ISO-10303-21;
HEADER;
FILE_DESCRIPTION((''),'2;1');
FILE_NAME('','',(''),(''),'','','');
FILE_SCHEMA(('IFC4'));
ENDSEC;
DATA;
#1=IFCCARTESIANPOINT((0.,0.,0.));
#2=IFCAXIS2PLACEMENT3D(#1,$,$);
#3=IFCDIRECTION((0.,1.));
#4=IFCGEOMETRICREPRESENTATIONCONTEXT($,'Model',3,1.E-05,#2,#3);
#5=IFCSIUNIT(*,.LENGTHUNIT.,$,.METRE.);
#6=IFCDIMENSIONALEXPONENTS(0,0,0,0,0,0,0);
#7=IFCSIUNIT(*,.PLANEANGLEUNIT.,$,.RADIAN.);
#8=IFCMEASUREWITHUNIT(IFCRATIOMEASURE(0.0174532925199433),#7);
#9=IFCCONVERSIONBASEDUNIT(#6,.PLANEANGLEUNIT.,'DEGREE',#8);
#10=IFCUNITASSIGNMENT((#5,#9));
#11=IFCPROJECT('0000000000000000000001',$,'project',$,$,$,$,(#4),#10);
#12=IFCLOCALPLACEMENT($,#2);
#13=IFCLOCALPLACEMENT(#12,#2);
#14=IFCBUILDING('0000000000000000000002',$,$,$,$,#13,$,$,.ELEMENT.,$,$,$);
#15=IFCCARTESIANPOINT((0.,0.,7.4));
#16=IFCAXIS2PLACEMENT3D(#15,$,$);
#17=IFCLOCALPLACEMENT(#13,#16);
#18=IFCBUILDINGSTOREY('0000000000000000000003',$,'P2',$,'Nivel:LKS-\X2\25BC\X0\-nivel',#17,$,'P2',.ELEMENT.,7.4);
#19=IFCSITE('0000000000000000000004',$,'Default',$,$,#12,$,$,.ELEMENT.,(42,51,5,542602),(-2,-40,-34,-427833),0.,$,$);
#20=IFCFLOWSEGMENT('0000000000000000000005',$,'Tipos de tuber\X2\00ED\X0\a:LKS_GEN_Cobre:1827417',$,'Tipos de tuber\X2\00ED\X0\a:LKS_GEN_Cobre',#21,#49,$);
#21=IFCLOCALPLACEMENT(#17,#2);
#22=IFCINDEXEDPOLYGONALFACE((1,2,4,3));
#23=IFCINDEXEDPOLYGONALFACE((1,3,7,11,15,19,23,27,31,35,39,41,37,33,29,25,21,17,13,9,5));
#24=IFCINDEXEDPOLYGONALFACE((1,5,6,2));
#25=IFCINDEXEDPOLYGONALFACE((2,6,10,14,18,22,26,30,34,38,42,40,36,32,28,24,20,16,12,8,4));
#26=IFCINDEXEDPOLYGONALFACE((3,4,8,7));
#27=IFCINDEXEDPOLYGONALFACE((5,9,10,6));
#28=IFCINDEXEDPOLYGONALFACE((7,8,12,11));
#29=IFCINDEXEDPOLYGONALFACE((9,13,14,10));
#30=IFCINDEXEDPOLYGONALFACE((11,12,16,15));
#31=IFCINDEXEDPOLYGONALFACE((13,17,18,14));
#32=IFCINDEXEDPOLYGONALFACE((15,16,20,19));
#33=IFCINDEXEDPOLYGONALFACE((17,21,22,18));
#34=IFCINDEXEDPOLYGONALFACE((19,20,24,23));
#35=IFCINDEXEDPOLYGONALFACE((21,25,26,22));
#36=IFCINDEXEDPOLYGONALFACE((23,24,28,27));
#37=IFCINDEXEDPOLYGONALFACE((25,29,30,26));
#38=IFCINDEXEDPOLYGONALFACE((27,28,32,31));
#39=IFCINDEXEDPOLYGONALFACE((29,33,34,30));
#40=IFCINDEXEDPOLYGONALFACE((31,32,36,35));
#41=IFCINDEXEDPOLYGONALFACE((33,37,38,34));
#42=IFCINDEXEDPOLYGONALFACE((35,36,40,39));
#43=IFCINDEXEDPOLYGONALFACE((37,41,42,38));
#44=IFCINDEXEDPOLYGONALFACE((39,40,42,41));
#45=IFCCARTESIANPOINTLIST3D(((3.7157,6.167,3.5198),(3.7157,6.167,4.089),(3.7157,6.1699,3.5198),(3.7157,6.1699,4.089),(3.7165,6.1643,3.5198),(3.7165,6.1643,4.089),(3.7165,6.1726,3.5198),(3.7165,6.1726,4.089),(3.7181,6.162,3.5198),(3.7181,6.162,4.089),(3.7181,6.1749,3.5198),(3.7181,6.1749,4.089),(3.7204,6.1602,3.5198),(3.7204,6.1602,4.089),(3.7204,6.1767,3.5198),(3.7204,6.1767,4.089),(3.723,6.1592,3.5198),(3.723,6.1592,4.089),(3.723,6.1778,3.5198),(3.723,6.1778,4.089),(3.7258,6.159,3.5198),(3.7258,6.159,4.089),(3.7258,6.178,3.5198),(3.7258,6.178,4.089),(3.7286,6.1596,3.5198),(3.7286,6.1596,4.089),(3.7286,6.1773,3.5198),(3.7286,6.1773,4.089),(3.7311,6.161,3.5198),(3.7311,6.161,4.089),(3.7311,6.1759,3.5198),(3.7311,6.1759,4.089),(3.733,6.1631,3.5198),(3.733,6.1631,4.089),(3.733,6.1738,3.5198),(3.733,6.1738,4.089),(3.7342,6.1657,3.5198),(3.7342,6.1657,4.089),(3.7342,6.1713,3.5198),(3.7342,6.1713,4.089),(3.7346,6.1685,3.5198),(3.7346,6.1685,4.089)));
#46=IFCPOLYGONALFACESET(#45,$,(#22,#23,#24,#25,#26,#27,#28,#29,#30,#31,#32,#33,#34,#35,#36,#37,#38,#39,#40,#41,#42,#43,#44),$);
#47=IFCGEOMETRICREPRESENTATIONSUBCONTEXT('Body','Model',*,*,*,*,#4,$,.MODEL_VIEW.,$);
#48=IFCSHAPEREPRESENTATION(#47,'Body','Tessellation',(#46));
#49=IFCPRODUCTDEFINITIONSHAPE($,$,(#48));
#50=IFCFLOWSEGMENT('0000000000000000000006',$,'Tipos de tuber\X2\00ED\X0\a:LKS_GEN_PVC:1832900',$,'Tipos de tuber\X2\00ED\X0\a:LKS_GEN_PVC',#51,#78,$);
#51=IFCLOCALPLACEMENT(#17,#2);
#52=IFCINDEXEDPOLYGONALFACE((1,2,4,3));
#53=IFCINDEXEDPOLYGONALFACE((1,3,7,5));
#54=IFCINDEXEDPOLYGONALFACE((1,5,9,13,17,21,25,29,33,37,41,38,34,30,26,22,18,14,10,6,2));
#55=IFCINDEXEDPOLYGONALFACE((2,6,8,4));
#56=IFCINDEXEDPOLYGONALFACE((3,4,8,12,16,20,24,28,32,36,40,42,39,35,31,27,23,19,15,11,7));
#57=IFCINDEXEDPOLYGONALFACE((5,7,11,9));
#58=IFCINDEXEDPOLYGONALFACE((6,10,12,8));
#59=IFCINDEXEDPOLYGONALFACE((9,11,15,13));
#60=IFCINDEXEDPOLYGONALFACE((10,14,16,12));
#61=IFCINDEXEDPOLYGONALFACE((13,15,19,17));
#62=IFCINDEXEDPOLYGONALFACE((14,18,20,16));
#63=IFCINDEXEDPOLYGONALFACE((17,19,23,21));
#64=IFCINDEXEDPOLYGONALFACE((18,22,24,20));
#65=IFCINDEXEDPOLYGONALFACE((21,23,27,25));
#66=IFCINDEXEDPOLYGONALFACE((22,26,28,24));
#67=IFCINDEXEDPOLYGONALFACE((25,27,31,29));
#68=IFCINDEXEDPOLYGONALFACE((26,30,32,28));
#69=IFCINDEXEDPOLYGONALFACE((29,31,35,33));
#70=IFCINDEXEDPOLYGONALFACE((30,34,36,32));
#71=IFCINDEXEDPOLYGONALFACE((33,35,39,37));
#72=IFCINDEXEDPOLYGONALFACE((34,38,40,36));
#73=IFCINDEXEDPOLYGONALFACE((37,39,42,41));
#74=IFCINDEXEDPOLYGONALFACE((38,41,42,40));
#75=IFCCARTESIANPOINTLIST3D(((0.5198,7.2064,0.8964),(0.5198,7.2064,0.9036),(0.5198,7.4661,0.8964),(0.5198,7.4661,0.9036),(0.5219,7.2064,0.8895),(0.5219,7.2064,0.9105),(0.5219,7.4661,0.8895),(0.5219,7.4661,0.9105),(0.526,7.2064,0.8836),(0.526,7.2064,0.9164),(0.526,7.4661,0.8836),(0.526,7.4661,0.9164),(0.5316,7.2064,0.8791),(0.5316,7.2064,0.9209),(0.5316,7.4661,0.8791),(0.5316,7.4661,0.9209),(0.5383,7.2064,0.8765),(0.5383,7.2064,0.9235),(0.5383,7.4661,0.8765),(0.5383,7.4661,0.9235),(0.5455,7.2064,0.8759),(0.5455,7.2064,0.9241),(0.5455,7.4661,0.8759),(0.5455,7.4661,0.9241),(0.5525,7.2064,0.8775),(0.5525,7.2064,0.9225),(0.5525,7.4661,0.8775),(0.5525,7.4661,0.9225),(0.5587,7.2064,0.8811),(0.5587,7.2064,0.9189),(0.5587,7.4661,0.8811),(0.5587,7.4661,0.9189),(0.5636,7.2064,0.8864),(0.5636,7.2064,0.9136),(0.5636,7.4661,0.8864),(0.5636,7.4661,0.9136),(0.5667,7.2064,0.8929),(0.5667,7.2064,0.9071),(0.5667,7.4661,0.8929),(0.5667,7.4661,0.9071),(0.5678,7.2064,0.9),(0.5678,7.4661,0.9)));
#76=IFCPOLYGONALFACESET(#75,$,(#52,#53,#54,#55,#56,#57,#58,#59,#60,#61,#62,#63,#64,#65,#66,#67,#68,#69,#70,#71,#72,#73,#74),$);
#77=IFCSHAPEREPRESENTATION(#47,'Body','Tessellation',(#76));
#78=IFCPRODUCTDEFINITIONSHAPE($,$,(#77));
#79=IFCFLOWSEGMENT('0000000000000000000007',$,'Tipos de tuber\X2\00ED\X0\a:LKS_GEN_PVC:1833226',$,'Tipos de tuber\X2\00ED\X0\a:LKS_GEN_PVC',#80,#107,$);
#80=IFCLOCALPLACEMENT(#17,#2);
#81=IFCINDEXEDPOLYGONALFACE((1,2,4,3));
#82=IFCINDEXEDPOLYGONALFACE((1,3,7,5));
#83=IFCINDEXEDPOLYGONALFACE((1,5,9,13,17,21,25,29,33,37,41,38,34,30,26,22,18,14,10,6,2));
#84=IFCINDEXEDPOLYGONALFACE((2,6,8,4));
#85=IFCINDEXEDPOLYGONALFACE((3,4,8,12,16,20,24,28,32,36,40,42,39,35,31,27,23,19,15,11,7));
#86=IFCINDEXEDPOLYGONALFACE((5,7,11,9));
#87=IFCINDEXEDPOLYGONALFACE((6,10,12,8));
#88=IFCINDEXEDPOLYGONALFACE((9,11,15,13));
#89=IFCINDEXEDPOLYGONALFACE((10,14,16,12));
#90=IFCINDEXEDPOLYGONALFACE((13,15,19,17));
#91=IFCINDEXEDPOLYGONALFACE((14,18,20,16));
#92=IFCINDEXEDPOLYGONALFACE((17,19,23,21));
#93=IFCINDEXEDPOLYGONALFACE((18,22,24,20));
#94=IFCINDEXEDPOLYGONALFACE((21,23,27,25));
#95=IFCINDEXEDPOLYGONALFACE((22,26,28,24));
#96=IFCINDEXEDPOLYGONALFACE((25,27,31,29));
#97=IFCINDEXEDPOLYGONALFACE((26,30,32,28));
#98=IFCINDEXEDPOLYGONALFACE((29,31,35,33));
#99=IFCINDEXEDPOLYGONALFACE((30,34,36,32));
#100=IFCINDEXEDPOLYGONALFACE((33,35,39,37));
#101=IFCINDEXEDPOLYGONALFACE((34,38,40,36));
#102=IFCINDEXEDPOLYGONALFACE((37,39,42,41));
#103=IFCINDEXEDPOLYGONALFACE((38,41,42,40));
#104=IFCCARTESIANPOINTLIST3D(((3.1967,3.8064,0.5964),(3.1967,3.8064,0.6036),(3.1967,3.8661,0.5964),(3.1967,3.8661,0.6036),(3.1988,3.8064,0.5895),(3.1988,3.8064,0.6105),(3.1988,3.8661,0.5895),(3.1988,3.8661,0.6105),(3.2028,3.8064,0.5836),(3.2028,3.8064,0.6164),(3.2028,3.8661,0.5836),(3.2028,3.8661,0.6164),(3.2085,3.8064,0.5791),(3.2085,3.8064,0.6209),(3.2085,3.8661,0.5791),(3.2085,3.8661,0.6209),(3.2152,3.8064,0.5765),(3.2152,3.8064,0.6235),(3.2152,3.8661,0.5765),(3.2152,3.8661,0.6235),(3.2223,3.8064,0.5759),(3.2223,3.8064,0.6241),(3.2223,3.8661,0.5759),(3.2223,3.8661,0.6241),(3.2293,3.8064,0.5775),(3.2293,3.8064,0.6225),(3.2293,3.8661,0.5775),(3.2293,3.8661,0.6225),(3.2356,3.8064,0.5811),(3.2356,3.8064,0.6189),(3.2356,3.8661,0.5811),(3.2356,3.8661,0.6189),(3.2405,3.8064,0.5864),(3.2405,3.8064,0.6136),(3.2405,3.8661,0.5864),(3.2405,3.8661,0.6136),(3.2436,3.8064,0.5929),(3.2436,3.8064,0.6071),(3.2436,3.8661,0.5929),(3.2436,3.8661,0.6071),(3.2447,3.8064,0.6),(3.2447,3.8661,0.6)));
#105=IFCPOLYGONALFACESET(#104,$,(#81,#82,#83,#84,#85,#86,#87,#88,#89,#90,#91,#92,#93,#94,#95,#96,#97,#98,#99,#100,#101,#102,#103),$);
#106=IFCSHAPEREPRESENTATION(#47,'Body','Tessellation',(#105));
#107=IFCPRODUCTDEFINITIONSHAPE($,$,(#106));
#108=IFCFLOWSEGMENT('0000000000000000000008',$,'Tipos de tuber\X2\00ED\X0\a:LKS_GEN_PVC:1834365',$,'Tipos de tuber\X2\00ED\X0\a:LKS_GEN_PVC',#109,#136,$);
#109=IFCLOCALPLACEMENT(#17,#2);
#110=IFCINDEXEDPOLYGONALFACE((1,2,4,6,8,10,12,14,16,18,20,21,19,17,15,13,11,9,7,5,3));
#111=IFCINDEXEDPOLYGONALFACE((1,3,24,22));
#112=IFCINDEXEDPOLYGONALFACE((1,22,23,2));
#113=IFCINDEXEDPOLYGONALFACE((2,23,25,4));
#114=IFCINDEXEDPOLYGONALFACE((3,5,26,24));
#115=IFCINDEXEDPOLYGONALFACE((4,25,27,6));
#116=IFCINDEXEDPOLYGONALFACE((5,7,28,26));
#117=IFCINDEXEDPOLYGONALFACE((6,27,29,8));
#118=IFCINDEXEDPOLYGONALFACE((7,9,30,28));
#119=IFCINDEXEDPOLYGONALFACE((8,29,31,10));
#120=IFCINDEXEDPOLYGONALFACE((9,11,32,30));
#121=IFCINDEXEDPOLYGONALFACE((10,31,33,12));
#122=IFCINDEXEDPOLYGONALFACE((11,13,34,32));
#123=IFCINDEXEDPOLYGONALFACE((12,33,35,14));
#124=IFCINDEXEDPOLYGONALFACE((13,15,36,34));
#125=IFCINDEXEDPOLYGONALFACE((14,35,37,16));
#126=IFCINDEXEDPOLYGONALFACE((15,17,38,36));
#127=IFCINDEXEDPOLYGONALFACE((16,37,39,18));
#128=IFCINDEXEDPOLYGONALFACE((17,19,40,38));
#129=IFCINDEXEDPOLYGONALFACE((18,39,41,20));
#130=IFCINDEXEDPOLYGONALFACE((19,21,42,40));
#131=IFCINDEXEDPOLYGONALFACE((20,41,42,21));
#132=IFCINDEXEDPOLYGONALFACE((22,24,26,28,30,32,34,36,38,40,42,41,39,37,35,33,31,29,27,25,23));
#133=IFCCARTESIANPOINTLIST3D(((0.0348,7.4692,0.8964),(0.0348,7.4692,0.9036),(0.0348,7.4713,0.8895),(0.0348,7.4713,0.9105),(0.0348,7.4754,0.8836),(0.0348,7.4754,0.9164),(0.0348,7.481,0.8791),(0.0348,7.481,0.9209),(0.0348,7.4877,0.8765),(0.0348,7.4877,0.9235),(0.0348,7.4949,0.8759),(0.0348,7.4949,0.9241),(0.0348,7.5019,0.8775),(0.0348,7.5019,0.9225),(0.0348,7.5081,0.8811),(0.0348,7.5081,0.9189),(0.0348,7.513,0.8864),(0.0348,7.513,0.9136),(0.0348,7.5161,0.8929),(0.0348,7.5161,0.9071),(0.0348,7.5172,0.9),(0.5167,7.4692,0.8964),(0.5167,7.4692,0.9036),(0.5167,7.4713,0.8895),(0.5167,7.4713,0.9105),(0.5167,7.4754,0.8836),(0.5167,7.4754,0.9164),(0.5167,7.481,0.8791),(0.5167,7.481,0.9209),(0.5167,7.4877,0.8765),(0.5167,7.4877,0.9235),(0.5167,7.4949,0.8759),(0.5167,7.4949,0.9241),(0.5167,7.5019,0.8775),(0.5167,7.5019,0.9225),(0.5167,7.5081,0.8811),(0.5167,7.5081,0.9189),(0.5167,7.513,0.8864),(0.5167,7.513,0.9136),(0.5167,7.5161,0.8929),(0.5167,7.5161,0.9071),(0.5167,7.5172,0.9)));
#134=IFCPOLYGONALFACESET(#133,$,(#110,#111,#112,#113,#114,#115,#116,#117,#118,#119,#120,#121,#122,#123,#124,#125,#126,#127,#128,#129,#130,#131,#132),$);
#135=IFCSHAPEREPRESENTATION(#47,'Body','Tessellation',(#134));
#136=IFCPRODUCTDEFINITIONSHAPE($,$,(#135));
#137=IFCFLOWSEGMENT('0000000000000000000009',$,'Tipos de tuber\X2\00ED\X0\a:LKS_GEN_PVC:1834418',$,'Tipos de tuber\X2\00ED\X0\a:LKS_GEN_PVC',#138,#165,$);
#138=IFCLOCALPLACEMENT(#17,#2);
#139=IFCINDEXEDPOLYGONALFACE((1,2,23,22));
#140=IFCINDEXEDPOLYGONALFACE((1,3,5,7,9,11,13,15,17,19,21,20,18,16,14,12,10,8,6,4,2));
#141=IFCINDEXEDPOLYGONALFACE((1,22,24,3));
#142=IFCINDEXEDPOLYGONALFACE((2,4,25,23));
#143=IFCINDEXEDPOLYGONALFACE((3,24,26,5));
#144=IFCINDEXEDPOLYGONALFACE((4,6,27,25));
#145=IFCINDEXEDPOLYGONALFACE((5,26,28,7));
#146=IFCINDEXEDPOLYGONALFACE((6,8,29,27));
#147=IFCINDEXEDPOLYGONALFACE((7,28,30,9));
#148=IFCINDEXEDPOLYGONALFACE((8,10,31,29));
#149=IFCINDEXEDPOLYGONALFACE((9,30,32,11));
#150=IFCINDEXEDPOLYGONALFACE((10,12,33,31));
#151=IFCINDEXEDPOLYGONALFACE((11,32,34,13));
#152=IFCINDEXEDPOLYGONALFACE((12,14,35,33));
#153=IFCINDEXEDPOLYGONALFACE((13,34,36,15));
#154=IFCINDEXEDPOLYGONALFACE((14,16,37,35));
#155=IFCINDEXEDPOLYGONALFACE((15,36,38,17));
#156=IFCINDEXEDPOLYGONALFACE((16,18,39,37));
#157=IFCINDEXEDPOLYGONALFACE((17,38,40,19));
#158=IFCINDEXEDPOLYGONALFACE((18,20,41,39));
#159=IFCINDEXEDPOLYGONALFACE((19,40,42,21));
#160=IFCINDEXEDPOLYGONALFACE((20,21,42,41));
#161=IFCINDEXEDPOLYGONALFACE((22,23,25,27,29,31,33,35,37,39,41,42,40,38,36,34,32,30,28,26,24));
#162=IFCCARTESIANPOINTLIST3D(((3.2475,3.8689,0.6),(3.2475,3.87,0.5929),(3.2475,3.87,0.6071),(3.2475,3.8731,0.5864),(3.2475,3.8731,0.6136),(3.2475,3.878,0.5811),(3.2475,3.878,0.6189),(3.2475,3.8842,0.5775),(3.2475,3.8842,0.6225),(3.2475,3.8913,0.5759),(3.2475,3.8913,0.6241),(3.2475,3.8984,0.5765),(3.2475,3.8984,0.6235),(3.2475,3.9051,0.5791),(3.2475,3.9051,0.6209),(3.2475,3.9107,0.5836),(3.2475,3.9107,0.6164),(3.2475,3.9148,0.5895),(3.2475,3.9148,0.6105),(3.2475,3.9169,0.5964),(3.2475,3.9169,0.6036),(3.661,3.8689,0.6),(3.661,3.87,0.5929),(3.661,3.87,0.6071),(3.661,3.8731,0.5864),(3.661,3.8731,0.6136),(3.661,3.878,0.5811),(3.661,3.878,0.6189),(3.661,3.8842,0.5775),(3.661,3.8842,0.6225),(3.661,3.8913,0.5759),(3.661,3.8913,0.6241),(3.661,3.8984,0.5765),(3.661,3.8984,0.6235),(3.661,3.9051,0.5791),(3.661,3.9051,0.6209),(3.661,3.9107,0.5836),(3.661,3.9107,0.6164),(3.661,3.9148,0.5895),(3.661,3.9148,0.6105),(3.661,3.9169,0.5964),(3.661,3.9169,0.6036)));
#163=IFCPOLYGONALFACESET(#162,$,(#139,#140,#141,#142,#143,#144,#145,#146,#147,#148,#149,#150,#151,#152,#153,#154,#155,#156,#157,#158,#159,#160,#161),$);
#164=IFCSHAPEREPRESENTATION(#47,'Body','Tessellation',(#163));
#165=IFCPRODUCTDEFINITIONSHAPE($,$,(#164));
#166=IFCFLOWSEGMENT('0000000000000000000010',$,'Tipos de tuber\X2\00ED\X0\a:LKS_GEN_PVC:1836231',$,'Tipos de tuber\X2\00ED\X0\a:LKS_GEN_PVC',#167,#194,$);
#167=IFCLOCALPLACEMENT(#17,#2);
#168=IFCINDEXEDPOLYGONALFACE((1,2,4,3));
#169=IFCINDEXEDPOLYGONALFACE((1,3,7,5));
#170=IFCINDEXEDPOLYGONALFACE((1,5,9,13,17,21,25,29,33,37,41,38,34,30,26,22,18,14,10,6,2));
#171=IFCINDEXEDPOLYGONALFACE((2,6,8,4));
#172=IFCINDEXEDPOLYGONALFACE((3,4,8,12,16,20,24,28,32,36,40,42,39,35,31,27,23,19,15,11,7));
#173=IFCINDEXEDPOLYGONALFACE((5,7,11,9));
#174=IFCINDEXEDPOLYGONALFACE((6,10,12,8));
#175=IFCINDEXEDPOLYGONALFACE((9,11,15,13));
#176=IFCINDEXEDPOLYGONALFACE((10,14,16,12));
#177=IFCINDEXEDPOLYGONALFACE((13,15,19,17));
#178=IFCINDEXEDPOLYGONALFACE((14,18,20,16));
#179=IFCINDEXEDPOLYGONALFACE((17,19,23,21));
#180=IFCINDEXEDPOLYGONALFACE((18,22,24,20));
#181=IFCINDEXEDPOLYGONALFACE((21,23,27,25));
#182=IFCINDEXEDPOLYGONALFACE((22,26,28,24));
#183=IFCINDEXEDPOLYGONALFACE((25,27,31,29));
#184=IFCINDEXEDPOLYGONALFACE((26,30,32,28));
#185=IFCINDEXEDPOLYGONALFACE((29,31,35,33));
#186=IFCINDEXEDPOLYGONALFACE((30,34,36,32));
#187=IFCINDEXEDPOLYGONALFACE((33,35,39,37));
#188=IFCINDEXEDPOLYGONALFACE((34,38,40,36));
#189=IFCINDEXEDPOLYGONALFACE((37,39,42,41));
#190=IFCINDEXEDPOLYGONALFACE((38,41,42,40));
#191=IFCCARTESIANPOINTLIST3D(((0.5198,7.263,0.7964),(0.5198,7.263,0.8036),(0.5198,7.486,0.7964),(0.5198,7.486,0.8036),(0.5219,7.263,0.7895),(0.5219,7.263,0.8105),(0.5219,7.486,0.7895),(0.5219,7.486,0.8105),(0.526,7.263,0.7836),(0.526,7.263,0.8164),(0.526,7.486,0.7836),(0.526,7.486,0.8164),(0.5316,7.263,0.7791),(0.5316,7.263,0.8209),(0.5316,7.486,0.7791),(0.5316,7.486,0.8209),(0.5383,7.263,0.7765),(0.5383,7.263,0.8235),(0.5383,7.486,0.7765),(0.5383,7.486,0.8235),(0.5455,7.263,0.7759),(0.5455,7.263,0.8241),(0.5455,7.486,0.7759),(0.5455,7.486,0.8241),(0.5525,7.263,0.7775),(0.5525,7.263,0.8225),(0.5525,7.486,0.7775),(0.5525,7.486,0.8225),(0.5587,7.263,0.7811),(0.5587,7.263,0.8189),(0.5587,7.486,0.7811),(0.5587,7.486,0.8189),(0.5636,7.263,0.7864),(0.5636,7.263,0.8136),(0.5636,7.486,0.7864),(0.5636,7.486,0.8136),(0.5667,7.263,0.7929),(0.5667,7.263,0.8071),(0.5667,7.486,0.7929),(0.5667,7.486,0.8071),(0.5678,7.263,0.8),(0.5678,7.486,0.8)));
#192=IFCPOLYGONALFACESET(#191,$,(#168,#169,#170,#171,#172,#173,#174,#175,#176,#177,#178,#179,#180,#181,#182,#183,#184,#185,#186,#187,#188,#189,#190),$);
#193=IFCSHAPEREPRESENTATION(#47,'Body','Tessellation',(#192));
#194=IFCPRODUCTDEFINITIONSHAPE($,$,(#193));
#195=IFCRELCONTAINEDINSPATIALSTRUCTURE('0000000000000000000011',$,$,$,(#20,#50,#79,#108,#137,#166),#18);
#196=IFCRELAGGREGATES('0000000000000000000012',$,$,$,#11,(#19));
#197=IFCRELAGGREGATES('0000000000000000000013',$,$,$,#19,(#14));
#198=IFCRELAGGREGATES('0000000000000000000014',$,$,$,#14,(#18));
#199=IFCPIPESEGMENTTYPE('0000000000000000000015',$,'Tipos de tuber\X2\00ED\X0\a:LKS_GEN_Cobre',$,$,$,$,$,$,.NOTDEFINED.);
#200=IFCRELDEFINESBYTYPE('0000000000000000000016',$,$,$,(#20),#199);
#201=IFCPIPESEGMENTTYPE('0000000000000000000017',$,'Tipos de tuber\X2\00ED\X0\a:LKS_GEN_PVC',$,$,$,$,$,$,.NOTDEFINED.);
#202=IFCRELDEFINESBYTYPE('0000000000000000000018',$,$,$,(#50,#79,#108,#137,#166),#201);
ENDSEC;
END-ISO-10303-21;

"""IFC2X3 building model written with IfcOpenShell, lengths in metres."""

from ifc_helpers import new_model, entity, si_unit, converted_unit, direction, frame, frame_2d, origin, origin_2d_with_axis, place, context, subcontext, project, spatial, circle, extrude, type_object, element, save


model = new_model("IFC2X3")

# Units and contexts
model_context = context("Model", 3, precision=1e-05, world=origin(), true_north=direction((0.0, 1.0)))
body_context = subcontext(model_context, "Body", "Model", "MODEL_VIEW")
ifc_project = project(units=[si_unit("LENGTHUNIT", "METRE"), converted_unit("PLANEANGLEUNIT", "DEGREE", entity("IfcRatioMeasure", 0.0174532925199433), si_unit("PLANEANGLEUNIT", "RADIAN"), dimensions=[0, 0, 0, 0, 0, 0, 0])], contexts=[model_context])

# Site, building, storey
site_placement = place(None, origin())
site = spatial("IfcSite", under=ifc_project, at=site_placement, Name="Default", CompositionType="ELEMENT", RefLatitude=(42, 51, 5, 542602), RefLongitude=(-2, -40, -34, -427833), RefElevation=0.0)
building_placement = place(site_placement, origin())
building = spatial("IfcBuilding", under=site, at=building_placement, CompositionType="ELEMENT")
storey_placement = place(building_placement, frame((0.0, 0.0, 7.4)))
storey = spatial("IfcBuildingStorey", under=building, at=storey_placement, Name="P2", ObjectType="Nivel:LKS-▼-nivel", LongName="P2", CompositionType="ELEMENT", Elevation=7.4)

# Flow segments
pipe_segment_type_1 = type_object("IfcPipeSegmentType", Name="Tipos de tubería:LKS_GEN_Cobre", PredefinedType="NOTDEFINED")
flow_segment_1_placement = place(storey_placement, origin())
element("IfcFlowSegment", 1, at=flow_segment_1_placement, inside=storey, type_object=pipe_segment_type_1, Name="Tipos de tubería:LKS_GEN_Cobre:1827417", ObjectType="Tipos de tubería:LKS_GEN_Cobre", context=body_context, shape_type="SweptSolid", body=[
    extrude(circle(Radius=0.0095, at=origin_2d_with_axis()), frame((3.7251, 6.1685, 3.5198)), (0.0, 0.0, 1.0), 0.5692),
])
pipe_segment_type_2 = type_object("IfcPipeSegmentType", Name="Tipos de tubería:LKS_GEN_PVC", PredefinedType="NOTDEFINED")
flow_segment_2_placement = place(storey_placement, origin())
element("IfcFlowSegment", 2, at=flow_segment_2_placement, inside=storey, type_object=pipe_segment_type_2, Name="Tipos de tubería:LKS_GEN_PVC:1832900", ObjectType="Tipos de tubería:LKS_GEN_PVC", context=body_context, shape_type="SweptSolid", body=[
    extrude(circle(Radius=0.0241, at=frame_2d((0.0, 0.0), x_axis=(1.0, 0.0))), frame((0.5437, 7.2064, 0.9), z_axis=(0.0, 1.0, 0.0), x_axis=(1.0, 0.0, 0.0)), (0.0, 0.0, 1.0), 0.2597),
])
flow_segment_3_placement = place(storey_placement, origin())
element("IfcFlowSegment", 3, at=flow_segment_3_placement, inside=storey, type_object=pipe_segment_type_2, Name="Tipos de tubería:LKS_GEN_PVC:1833226", ObjectType="Tipos de tubería:LKS_GEN_PVC", context=body_context, shape_type="SweptSolid", body=[
    extrude(circle(Radius=0.0241, at=origin_2d_with_axis()), frame((3.2205, 3.8064, 0.6), z_axis=(0.0, 1.0, 0.0), x_axis=(1.0, 0.0, 0.0)), (0.0, 0.0, 1.0), 0.0597),
])
flow_segment_4_placement = place(storey_placement, origin())
element("IfcFlowSegment", 4, at=flow_segment_4_placement, inside=storey, type_object=pipe_segment_type_2, Name="Tipos de tubería:LKS_GEN_PVC:1834365", ObjectType="Tipos de tubería:LKS_GEN_PVC", context=body_context, shape_type="SweptSolid", body=[
    extrude(circle(Radius=0.0241, at=frame_2d((0.0, 0.0), x_axis=(1.0, 0.0))), frame((0.0348, 7.4931, 0.9), z_axis=(1.0, 0.0, 0.0), x_axis=(0.0, 1.0, 0.0)), (0.0, 0.0, 1.0), 0.4819),
])
flow_segment_5_placement = place(storey_placement, origin())
element("IfcFlowSegment", 5, at=flow_segment_5_placement, inside=storey, type_object=pipe_segment_type_2, Name="Tipos de tubería:LKS_GEN_PVC:1834418", ObjectType="Tipos de tubería:LKS_GEN_PVC", context=body_context, shape_type="SweptSolid", body=[
    extrude(circle(Radius=0.0241, at=frame_2d((0.0, 0.0), x_axis=(1.0, 0.0))), frame((3.2475, 3.8931, 0.6), z_axis=(1.0, 0.0, 0.0), x_axis=(0.0, -1.0, 0.0)), (0.0, 0.0, 1.0), 0.4135),
])
flow_segment_6_placement = place(storey_placement, origin())
element("IfcFlowSegment", 6, at=flow_segment_6_placement, inside=storey, type_object=pipe_segment_type_2, Name="Tipos de tubería:LKS_GEN_PVC:1836231", ObjectType="Tipos de tubería:LKS_GEN_PVC", context=body_context, shape_type="SweptSolid", body=[
    extrude(circle(Radius=0.0241, at=frame_2d((0.0, 0.0), x_axis=(1.0, 0.0))), frame((0.5437, 7.263, 0.8), z_axis=(0.0, 1.0, 0.0), x_axis=(1.0, 0.0, 0.0)), (0.0, 0.0, 1.0), 0.223),
])

save(model, "model.ifc")
